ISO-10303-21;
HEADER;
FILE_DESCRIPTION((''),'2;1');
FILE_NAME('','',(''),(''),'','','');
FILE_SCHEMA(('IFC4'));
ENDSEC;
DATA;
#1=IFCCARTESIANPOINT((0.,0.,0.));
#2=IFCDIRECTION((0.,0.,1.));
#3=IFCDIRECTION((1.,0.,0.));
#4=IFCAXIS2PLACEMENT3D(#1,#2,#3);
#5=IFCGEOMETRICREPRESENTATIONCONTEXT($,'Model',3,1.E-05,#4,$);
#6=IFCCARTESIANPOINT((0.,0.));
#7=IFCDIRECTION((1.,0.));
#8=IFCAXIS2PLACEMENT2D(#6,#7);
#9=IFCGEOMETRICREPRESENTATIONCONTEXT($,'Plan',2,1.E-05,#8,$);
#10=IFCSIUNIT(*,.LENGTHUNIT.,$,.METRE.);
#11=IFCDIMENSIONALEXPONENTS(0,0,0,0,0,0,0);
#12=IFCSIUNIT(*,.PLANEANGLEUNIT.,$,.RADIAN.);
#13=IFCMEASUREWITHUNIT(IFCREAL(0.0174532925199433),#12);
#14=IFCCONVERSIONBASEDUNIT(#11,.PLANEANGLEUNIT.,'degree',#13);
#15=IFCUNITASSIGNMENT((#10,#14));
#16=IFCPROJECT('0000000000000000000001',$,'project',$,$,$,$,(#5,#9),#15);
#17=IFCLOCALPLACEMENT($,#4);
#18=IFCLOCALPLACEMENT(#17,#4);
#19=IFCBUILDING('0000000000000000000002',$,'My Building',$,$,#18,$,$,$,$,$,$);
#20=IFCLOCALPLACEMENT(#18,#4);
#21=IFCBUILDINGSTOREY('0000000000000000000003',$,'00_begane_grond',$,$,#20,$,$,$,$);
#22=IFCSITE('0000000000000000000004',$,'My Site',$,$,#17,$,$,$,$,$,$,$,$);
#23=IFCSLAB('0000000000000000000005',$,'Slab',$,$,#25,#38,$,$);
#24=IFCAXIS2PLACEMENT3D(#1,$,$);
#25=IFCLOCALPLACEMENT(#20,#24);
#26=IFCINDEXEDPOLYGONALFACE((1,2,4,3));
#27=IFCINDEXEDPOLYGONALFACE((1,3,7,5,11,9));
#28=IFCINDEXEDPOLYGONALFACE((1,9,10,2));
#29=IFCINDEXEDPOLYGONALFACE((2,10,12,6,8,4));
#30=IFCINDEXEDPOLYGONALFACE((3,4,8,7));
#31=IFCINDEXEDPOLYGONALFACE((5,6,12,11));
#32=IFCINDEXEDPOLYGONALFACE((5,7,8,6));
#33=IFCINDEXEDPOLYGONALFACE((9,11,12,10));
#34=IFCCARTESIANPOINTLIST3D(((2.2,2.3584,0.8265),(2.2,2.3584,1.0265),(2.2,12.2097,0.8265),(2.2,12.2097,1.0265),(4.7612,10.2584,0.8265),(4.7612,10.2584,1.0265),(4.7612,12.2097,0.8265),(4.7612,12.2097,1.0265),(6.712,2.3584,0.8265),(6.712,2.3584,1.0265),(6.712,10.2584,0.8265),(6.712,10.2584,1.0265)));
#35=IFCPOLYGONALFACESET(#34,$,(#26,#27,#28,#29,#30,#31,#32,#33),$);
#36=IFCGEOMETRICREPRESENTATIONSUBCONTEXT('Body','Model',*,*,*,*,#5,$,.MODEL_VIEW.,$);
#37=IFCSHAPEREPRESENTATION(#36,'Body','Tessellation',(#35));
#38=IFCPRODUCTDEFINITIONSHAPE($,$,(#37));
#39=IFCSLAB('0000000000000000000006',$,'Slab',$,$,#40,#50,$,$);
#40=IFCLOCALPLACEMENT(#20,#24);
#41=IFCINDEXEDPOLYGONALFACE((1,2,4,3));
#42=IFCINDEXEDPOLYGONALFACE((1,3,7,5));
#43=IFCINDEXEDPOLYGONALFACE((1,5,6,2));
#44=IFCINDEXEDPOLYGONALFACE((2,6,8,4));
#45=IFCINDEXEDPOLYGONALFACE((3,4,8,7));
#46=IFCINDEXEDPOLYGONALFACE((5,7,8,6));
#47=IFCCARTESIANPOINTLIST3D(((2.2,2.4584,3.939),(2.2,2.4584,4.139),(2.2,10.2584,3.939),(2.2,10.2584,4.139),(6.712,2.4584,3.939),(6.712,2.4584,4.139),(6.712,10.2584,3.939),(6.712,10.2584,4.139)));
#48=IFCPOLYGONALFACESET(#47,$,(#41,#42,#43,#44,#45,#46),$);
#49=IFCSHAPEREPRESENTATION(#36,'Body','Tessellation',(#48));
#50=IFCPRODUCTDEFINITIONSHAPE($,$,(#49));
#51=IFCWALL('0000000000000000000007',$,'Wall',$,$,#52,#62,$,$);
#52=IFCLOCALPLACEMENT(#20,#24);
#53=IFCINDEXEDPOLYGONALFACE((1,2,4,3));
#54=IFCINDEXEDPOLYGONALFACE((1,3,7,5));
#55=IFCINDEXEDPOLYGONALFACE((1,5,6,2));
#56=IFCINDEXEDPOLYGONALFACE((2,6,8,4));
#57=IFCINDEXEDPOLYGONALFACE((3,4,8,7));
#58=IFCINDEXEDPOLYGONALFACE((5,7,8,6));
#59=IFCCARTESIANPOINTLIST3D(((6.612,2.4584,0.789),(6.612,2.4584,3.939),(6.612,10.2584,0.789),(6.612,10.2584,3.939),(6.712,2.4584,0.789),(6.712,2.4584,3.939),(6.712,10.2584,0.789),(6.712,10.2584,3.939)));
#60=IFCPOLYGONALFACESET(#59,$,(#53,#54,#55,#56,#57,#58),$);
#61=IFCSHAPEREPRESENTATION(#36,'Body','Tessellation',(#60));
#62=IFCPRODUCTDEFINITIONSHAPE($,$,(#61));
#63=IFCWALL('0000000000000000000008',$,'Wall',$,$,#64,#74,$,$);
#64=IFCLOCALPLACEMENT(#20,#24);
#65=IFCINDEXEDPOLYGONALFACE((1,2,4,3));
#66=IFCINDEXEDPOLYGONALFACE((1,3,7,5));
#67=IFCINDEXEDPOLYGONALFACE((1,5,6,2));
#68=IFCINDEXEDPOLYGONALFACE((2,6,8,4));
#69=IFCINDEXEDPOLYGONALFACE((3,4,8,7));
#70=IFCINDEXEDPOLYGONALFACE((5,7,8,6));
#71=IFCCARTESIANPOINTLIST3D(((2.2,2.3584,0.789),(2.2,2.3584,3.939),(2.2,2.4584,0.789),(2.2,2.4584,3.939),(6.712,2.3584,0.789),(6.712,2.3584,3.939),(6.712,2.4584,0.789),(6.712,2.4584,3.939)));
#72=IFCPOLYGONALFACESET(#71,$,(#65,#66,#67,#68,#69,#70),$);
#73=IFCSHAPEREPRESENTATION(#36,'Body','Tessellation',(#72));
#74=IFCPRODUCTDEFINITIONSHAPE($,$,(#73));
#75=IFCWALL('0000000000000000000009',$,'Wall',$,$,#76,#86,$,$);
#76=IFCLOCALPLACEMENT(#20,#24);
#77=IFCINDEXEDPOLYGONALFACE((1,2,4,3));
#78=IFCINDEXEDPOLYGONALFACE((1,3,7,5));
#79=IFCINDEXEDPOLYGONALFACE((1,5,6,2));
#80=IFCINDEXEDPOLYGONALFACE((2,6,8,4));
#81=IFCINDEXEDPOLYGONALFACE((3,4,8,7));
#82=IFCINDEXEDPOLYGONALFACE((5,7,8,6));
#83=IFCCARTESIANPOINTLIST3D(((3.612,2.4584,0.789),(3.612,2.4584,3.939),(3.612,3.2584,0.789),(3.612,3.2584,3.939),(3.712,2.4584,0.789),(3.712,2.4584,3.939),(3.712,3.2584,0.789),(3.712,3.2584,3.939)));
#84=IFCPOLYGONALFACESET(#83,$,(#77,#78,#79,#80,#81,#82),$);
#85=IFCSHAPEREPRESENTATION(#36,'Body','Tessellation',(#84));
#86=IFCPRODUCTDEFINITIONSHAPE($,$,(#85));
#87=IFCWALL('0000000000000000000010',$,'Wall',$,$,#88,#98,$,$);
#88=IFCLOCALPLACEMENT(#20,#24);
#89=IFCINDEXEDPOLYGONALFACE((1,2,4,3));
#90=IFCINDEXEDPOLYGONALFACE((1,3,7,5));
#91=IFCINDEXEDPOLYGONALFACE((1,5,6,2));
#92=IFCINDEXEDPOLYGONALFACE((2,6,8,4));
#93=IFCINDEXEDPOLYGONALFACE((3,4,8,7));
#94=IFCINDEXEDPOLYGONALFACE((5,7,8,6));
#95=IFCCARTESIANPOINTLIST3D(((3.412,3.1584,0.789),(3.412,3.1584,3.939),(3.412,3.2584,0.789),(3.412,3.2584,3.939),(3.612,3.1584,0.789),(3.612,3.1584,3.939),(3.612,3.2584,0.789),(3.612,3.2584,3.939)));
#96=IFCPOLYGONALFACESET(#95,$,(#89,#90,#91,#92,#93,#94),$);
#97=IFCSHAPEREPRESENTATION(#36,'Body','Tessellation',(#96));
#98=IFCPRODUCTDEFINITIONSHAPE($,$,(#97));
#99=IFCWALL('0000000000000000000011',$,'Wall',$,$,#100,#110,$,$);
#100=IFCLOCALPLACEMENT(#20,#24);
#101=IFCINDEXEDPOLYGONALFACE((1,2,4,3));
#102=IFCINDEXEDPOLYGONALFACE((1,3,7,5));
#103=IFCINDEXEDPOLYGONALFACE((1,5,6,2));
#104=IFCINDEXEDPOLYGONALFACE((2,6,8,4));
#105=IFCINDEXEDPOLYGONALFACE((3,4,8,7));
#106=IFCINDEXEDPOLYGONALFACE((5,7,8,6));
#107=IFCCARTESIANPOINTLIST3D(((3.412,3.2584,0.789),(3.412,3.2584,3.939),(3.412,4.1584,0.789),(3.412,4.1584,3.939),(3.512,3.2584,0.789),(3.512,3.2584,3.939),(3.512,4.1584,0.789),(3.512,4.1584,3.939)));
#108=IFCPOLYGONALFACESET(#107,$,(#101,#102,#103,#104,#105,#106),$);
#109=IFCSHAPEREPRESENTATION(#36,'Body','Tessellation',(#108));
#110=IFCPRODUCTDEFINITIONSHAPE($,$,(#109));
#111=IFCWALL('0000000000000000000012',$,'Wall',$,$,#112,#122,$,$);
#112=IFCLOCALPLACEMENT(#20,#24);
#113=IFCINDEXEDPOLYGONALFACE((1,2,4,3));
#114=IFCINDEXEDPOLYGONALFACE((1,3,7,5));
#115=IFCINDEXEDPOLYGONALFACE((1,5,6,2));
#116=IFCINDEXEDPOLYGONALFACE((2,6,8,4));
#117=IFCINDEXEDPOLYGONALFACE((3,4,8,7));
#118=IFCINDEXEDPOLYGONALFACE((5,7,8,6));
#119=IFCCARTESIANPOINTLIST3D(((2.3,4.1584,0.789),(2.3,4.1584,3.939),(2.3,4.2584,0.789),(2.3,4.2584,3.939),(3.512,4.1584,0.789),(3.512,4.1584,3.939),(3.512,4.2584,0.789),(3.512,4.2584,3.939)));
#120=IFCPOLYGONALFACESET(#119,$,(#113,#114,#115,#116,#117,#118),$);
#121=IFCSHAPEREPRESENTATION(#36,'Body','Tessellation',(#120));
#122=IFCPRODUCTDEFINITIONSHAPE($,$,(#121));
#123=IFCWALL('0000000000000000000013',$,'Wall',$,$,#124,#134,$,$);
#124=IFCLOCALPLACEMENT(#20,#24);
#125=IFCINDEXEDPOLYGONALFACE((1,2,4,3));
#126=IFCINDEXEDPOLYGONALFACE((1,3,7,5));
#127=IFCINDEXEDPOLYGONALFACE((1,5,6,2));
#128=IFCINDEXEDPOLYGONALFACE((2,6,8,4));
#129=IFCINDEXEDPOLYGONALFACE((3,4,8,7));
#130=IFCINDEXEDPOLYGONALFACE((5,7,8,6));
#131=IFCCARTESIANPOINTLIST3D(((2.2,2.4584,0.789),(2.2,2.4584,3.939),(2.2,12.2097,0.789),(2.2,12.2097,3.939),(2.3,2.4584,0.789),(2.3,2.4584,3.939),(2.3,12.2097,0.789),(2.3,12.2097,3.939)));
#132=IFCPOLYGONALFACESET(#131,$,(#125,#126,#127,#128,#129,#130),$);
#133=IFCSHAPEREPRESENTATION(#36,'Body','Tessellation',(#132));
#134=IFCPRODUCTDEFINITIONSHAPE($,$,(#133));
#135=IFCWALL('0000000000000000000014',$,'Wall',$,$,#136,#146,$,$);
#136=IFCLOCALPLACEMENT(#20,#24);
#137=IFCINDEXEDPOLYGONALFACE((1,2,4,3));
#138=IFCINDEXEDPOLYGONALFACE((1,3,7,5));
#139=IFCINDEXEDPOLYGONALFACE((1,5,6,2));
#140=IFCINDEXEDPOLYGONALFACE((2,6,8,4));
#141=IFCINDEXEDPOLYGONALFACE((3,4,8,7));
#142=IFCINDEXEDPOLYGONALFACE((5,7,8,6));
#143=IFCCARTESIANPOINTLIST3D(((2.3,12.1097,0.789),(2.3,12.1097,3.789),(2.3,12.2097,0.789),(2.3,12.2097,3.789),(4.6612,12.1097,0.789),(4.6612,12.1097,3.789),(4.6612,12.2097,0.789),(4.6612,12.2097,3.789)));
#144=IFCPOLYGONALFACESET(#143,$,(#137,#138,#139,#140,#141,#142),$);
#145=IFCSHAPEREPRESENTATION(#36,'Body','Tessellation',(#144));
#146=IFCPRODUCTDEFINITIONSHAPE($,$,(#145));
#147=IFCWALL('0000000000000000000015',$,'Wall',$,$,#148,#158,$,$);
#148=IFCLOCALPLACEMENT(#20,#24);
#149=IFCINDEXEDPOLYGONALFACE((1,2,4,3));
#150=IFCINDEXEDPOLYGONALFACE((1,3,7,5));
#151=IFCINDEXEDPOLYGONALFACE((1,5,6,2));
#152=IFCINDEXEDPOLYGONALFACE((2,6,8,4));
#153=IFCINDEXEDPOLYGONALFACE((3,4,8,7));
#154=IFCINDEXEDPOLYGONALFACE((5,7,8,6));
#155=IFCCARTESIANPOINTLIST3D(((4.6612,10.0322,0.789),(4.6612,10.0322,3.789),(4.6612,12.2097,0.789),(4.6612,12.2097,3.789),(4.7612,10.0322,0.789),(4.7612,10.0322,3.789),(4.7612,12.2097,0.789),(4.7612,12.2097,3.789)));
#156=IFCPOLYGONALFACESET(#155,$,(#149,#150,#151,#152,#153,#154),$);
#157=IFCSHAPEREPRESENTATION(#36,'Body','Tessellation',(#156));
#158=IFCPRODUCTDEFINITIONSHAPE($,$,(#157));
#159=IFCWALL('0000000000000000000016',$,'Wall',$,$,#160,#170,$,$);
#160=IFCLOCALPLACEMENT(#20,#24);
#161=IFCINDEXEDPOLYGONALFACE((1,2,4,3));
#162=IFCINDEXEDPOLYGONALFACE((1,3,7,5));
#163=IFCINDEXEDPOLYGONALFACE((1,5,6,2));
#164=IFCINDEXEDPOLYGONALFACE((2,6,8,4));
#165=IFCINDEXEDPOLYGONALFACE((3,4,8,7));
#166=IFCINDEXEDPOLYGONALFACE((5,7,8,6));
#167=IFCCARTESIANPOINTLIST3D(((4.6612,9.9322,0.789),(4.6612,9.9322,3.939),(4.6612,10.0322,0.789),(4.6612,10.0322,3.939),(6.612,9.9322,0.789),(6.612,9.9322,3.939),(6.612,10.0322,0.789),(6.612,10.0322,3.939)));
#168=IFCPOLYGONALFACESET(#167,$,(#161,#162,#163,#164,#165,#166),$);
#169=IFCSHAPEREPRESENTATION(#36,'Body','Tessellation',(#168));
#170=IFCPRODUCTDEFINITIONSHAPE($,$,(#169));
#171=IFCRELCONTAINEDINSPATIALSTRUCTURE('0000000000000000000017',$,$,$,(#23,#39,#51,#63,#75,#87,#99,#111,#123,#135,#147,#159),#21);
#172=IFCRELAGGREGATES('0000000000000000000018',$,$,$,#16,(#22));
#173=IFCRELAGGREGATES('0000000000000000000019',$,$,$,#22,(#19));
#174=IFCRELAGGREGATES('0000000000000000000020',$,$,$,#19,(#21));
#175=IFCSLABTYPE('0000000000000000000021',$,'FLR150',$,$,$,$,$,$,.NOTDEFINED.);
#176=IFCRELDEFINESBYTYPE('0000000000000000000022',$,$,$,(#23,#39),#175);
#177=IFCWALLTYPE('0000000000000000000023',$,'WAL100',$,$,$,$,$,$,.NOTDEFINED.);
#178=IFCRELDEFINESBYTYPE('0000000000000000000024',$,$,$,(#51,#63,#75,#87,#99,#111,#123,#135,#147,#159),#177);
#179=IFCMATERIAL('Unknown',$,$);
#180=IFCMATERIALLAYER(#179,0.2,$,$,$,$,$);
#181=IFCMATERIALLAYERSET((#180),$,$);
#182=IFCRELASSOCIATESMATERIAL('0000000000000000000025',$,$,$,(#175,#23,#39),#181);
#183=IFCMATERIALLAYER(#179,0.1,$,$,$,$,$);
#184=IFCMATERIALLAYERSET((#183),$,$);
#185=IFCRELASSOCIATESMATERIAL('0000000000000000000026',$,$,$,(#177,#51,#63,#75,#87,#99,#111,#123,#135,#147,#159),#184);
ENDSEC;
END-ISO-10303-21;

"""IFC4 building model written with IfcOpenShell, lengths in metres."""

from ifc_helpers import new_model, entity, si_unit, converted_unit, frame, origin_with_axes, origin_2d_with_axis, place, context, subcontext, project, spatial, line, indexed_curve, outline, extrude, clip, halfspace, material, layer, layer_set, layer_usage, type_object, element, save


model = new_model("IFC4")

# Units and contexts
model_context = context("Model", 3, precision=1e-05, world=origin_with_axes())
plan_context = context("Plan", 2, precision=1e-05, world=origin_2d_with_axis())
body_context = subcontext(model_context, "Body", "Model", "MODEL_VIEW")
ifc_project = project(units=[si_unit("LENGTHUNIT", "METRE"), converted_unit("PLANEANGLEUNIT", "degree", entity("IfcReal", 0.0174532925199433), si_unit("PLANEANGLEUNIT", "RADIAN"), dimensions=[0, 0, 0, 0, 0, 0, 0])], contexts=[model_context, plan_context])

# Site, building, storey
site_placement = place(None, origin_with_axes())
site = spatial("IfcSite", under=ifc_project, at=site_placement, Name="My Site")
building_placement = place(site_placement, origin_with_axes())
building = spatial("IfcBuilding", under=site, at=building_placement, Name="My Building")
storey_placement = place(building_placement, origin_with_axes())
storey = spatial("IfcBuildingStorey", under=building, at=storey_placement, Name="00_begane_grond")

# Slabs
ifc_material = material(Name="Unknown")
ifc_layer_1 = layer(ifc_material, 0.2)
ifc_layer_set_1 = layer_set([ifc_layer_1])
ifc_layer_usage_1 = layer_usage(ifc_layer_set_1, "AXIS3", "POSITIVE", 0.0)
slab_type = type_object("IfcSlabType", Name="FLR150", PredefinedType="NOTDEFINED", material=ifc_layer_set_1)
slab_1_placement = place(storey_placement, frame((2.2, 2.3584, 0.8265), z_axis=(0.0, 0.0, 1.0), x_axis=(1.0, 0.0, 0.0)))
element("IfcSlab", 1, at=slab_1_placement, inside=storey, type_object=slab_type, material=ifc_layer_usage_1, Name="Slab", context=body_context, shape_type="SweptSolid", body=[
    extrude(outline(indexed_curve([(0.0, 0.0), (4.512, 0.0), (4.512, 7.9), (0.0, 9.8513), (2.5611, 7.9), (2.5611, 9.8513)], segments=[line(3, 2), line(2, 1), line(1, 4), line(4, 6), line(6, 5), line(5, 3)], self_intersect=False)), None, (0.0, 0.0, 1.0), 0.2),
])
ifc_layer_usage_2 = layer_usage(ifc_layer_set_1, "AXIS3", "POSITIVE", 0.0)
slab_2_placement = place(storey_placement, frame((2.2, 2.4584, 3.939), z_axis=(0.0, 0.0, 1.0), x_axis=(1.0, 0.0, 0.0)))
element("IfcSlab", 2, at=slab_2_placement, inside=storey, type_object=slab_type, material=ifc_layer_usage_2, Name="Slab", context=body_context, shape_type="SweptSolid", body=[
    extrude(outline(indexed_curve([(0.0, 0.0), (4.512, 0.0), (4.512, 7.8), (0.0, 7.8)], segments=[line(3, 2), line(2, 1), line(1, 4), line(4, 3)], self_intersect=False)), None, (0.0, 0.0, 1.0), 0.2),
])

# Walls
ifc_layer_2 = layer(ifc_material, 0.1)
ifc_layer_set_2 = layer_set([ifc_layer_2])
ifc_layer_usage_3 = layer_usage(ifc_layer_set_2, "AXIS2", "POSITIVE", 0.0)
wall_type = type_object("IfcWallType", Name="WAL100", PredefinedType="NOTDEFINED", material=ifc_layer_set_2)
wall_1_placement = place(storey_placement, frame((6.612, 10.2584, 0.789), z_axis=(0.0, 0.0, 1.0), x_axis=(0.0, -1.0, 0.0)))
element("IfcWall", 3, at=wall_1_placement, inside=storey, type_object=wall_type, material=ifc_layer_usage_3, Name="Wall", context=body_context, shape_type="Clipping", body=[
    clip(extrude(outline(indexed_curve([(0.0, 0.0), (0.0, 0.1), (7.8, 0.1), (7.8, 0.0), (0.0, 0.0)], self_intersect=False)), origin_with_axes(), (0.0, 0.0, 1.0), 3.939), halfspace(frame((0.0, 0.0, 3.15), z_axis=(0.0, 0.0, 1.0), x_axis=(-1.0, 0.0, 0.0)), False)),
])
ifc_layer_usage_4 = layer_usage(ifc_layer_set_2, "AXIS2", "POSITIVE", 0.0)
wall_2_placement = place(storey_placement, frame((6.712, 2.4584, 0.789), z_axis=(0.0, 0.0, 1.0), x_axis=(-1.0, 0.0, 0.0)))
element("IfcWall", 4, at=wall_2_placement, inside=storey, type_object=wall_type, material=ifc_layer_usage_4, Name="Wall", context=body_context, shape_type="Clipping", body=[
    clip(extrude(outline(indexed_curve([(0.0, 0.0), (0.0, 0.1), (4.512, 0.1), (4.512, 0.0), (0.0, 0.0)], self_intersect=False)), origin_with_axes(), (0.0, 0.0, 1.0), 3.939), halfspace(frame((0.0, 0.0, 3.15), z_axis=(0.0, 0.0, 1.0), x_axis=(-1.0, 0.0, 0.0)), False)),
])
ifc_layer_usage_5 = layer_usage(ifc_layer_set_2, "AXIS2", "POSITIVE", 0.0)
wall_3_placement = place(storey_placement, frame((3.712, 2.4584, 0.789), z_axis=(0.0, 0.0, 1.0), x_axis=(0.000001, 1.0, 0.0)))
element("IfcWall", 5, at=wall_3_placement, inside=storey, type_object=wall_type, material=ifc_layer_usage_5, Name="Wall", context=body_context, shape_type="Clipping", body=[
    clip(extrude(outline(indexed_curve([(0.0, 0.0), (0.0, 0.1), (0.8, 0.1), (0.8, 0.0), (0.0, 0.0)], self_intersect=False)), origin_with_axes(), (0.0, 0.0, 1.0), 3.939), halfspace(frame((0.0, 0.0, 3.15), z_axis=(0.0, 0.0, 1.0), x_axis=(-1.0, 0.0, 0.0)), False)),
])
ifc_layer_usage_6 = layer_usage(ifc_layer_set_2, "AXIS2", "POSITIVE", 0.0)
wall_4_placement = place(storey_placement, frame((3.612, 3.2584, 0.789), z_axis=(0.0, 0.0, 1.0), x_axis=(-1.0, 0.000001, 0.0)))
element("IfcWall", 6, at=wall_4_placement, inside=storey, type_object=wall_type, material=ifc_layer_usage_6, Name="Wall", context=body_context, shape_type="Clipping", body=[
    clip(extrude(outline(indexed_curve([(0.0, 0.0), (0.0, 0.1), (0.2, 0.1), (0.2, 0.0), (0.0, 0.0)], self_intersect=False)), origin_with_axes(), (0.0, 0.0, 1.0), 3.939), halfspace(frame((0.0, 0.0, 3.15), z_axis=(0.0, 0.0, 1.0), x_axis=(-1.0, 0.0, 0.0)), False)),
])
ifc_layer_usage_7 = layer_usage(ifc_layer_set_2, "AXIS2", "POSITIVE", 0.0)
wall_5_placement = place(storey_placement, frame((3.512, 3.2584, 0.789), z_axis=(0.0, 0.0, 1.0), x_axis=(0.000001, 1.0, 0.0)))
element("IfcWall", 7, at=wall_5_placement, inside=storey, type_object=wall_type, material=ifc_layer_usage_7, Name="Wall", context=body_context, shape_type="Clipping", body=[
    clip(extrude(outline(indexed_curve([(0.0, 0.0), (0.0, 0.1), (0.9, 0.1), (0.9, 0.0), (0.0, 0.0)], self_intersect=False)), origin_with_axes(), (0.0, 0.0, 1.0), 3.939), halfspace(frame((0.0, 0.0, 3.15), z_axis=(0.0, 0.0, 1.0), x_axis=(-1.0, 0.0, 0.0)), False)),
])
ifc_layer_usage_8 = layer_usage(ifc_layer_set_2, "AXIS2", "POSITIVE", 0.0)
wall_6_placement = place(storey_placement, frame((3.512, 4.2584, 0.789), z_axis=(0.0, 0.0, 1.0), x_axis=(-1.0, 0.0, 0.0)))
element("IfcWall", 8, at=wall_6_placement, inside=storey, type_object=wall_type, material=ifc_layer_usage_8, Name="Wall", context=body_context, shape_type="Clipping", body=[
    clip(extrude(outline(indexed_curve([(0.0, 0.0), (0.0, 0.1), (1.212, 0.1), (1.212, 0.0), (0.0, 0.0)], self_intersect=False)), origin_with_axes(), (0.0, 0.0, 1.0), 3.939), halfspace(frame((0.0, 0.0, 3.15), z_axis=(0.0, 0.0, 1.0), x_axis=(-1.0, 0.0, 0.0)), False)),
])
ifc_layer_usage_9 = layer_usage(ifc_layer_set_2, "AXIS2", "POSITIVE", 0.0)
wall_7_placement = place(storey_placement, frame((2.3, 2.4584, 0.789), z_axis=(0.0, 0.0, 1.0), x_axis=(0.000001, 1.0, 0.0)))
element("IfcWall", 9, at=wall_7_placement, inside=storey, type_object=wall_type, material=ifc_layer_usage_9, Name="Wall", context=body_context, shape_type="Clipping", body=[
    clip(extrude(outline(indexed_curve([(0.0, 0.0), (0.0, 0.1), (9.7513, 0.1), (9.7513, 0.0), (0.0, 0.0)], self_intersect=False)), origin_with_axes(), (0.0, 0.0, 1.0), 3.939), halfspace(frame((0.0, 0.0, 3.15), z_axis=(0.0, 0.0, 1.0), x_axis=(-1.0, 0.0, 0.0)), False)),
])
ifc_layer_usage_10 = layer_usage(ifc_layer_set_2, "AXIS2", "POSITIVE", 0.0)
wall_8_placement = place(storey_placement, frame((2.3, 12.1097, 0.789), z_axis=(0.0, 0.0, 1.0), x_axis=(1.0, -0.000001, 0.0)))
element("IfcWall", 10, at=wall_8_placement, inside=storey, type_object=wall_type, material=ifc_layer_usage_10, Name="Wall", context=body_context, shape_type="SweptSolid", body=[
    extrude(outline(indexed_curve([(0.0, 0.0), (0.0, 0.1), (2.3611, 0.1), (2.3611, 0.0), (0.0, 0.0)], self_intersect=False)), origin_with_axes(), (0.0, 0.0, 1.0), 3.0),
])
ifc_layer_usage_11 = layer_usage(ifc_layer_set_2, "AXIS2", "POSITIVE", 0.0)
wall_9_placement = place(storey_placement, frame((4.6612, 12.2097, 0.789), z_axis=(0.0, 0.0, 1.0), x_axis=(-0.000001, -1.0, 0.0)))
element("IfcWall", 11, at=wall_9_placement, inside=storey, type_object=wall_type, material=ifc_layer_usage_11, Name="Wall", context=body_context, shape_type="SweptSolid", body=[
    extrude(outline(indexed_curve([(0.0, 0.0), (0.0, 0.1), (2.1775, 0.1), (2.1775, 0.0), (0.0, 0.0)], self_intersect=False)), origin_with_axes(), (0.0, 0.0, 1.0), 3.0),
])
ifc_layer_usage_12 = layer_usage(ifc_layer_set_2, "AXIS2", "POSITIVE", 0.0)
wall_10_placement = place(storey_placement, frame((4.6612, 9.9322, 0.789), z_axis=(0.0, 0.0, 1.0), x_axis=(1.0, -0.000001, 0.0)))
element("IfcWall", 12, at=wall_10_placement, inside=storey, type_object=wall_type, material=ifc_layer_usage_12, Name="Wall", context=body_context, shape_type="Clipping", body=[
    clip(extrude(outline(indexed_curve([(0.0, 0.0), (0.0, 0.1), (1.9508, 0.1), (1.9508, 0.0), (0.0, 0.0)], self_intersect=False)), origin_with_axes(), (0.0, 0.0, 1.0), 3.939), halfspace(frame((0.0, 0.0, 3.15), z_axis=(0.0, 0.0, 1.0), x_axis=(-1.0, 0.0, 0.0)), False)),
])

save(model, "model.ifc")
